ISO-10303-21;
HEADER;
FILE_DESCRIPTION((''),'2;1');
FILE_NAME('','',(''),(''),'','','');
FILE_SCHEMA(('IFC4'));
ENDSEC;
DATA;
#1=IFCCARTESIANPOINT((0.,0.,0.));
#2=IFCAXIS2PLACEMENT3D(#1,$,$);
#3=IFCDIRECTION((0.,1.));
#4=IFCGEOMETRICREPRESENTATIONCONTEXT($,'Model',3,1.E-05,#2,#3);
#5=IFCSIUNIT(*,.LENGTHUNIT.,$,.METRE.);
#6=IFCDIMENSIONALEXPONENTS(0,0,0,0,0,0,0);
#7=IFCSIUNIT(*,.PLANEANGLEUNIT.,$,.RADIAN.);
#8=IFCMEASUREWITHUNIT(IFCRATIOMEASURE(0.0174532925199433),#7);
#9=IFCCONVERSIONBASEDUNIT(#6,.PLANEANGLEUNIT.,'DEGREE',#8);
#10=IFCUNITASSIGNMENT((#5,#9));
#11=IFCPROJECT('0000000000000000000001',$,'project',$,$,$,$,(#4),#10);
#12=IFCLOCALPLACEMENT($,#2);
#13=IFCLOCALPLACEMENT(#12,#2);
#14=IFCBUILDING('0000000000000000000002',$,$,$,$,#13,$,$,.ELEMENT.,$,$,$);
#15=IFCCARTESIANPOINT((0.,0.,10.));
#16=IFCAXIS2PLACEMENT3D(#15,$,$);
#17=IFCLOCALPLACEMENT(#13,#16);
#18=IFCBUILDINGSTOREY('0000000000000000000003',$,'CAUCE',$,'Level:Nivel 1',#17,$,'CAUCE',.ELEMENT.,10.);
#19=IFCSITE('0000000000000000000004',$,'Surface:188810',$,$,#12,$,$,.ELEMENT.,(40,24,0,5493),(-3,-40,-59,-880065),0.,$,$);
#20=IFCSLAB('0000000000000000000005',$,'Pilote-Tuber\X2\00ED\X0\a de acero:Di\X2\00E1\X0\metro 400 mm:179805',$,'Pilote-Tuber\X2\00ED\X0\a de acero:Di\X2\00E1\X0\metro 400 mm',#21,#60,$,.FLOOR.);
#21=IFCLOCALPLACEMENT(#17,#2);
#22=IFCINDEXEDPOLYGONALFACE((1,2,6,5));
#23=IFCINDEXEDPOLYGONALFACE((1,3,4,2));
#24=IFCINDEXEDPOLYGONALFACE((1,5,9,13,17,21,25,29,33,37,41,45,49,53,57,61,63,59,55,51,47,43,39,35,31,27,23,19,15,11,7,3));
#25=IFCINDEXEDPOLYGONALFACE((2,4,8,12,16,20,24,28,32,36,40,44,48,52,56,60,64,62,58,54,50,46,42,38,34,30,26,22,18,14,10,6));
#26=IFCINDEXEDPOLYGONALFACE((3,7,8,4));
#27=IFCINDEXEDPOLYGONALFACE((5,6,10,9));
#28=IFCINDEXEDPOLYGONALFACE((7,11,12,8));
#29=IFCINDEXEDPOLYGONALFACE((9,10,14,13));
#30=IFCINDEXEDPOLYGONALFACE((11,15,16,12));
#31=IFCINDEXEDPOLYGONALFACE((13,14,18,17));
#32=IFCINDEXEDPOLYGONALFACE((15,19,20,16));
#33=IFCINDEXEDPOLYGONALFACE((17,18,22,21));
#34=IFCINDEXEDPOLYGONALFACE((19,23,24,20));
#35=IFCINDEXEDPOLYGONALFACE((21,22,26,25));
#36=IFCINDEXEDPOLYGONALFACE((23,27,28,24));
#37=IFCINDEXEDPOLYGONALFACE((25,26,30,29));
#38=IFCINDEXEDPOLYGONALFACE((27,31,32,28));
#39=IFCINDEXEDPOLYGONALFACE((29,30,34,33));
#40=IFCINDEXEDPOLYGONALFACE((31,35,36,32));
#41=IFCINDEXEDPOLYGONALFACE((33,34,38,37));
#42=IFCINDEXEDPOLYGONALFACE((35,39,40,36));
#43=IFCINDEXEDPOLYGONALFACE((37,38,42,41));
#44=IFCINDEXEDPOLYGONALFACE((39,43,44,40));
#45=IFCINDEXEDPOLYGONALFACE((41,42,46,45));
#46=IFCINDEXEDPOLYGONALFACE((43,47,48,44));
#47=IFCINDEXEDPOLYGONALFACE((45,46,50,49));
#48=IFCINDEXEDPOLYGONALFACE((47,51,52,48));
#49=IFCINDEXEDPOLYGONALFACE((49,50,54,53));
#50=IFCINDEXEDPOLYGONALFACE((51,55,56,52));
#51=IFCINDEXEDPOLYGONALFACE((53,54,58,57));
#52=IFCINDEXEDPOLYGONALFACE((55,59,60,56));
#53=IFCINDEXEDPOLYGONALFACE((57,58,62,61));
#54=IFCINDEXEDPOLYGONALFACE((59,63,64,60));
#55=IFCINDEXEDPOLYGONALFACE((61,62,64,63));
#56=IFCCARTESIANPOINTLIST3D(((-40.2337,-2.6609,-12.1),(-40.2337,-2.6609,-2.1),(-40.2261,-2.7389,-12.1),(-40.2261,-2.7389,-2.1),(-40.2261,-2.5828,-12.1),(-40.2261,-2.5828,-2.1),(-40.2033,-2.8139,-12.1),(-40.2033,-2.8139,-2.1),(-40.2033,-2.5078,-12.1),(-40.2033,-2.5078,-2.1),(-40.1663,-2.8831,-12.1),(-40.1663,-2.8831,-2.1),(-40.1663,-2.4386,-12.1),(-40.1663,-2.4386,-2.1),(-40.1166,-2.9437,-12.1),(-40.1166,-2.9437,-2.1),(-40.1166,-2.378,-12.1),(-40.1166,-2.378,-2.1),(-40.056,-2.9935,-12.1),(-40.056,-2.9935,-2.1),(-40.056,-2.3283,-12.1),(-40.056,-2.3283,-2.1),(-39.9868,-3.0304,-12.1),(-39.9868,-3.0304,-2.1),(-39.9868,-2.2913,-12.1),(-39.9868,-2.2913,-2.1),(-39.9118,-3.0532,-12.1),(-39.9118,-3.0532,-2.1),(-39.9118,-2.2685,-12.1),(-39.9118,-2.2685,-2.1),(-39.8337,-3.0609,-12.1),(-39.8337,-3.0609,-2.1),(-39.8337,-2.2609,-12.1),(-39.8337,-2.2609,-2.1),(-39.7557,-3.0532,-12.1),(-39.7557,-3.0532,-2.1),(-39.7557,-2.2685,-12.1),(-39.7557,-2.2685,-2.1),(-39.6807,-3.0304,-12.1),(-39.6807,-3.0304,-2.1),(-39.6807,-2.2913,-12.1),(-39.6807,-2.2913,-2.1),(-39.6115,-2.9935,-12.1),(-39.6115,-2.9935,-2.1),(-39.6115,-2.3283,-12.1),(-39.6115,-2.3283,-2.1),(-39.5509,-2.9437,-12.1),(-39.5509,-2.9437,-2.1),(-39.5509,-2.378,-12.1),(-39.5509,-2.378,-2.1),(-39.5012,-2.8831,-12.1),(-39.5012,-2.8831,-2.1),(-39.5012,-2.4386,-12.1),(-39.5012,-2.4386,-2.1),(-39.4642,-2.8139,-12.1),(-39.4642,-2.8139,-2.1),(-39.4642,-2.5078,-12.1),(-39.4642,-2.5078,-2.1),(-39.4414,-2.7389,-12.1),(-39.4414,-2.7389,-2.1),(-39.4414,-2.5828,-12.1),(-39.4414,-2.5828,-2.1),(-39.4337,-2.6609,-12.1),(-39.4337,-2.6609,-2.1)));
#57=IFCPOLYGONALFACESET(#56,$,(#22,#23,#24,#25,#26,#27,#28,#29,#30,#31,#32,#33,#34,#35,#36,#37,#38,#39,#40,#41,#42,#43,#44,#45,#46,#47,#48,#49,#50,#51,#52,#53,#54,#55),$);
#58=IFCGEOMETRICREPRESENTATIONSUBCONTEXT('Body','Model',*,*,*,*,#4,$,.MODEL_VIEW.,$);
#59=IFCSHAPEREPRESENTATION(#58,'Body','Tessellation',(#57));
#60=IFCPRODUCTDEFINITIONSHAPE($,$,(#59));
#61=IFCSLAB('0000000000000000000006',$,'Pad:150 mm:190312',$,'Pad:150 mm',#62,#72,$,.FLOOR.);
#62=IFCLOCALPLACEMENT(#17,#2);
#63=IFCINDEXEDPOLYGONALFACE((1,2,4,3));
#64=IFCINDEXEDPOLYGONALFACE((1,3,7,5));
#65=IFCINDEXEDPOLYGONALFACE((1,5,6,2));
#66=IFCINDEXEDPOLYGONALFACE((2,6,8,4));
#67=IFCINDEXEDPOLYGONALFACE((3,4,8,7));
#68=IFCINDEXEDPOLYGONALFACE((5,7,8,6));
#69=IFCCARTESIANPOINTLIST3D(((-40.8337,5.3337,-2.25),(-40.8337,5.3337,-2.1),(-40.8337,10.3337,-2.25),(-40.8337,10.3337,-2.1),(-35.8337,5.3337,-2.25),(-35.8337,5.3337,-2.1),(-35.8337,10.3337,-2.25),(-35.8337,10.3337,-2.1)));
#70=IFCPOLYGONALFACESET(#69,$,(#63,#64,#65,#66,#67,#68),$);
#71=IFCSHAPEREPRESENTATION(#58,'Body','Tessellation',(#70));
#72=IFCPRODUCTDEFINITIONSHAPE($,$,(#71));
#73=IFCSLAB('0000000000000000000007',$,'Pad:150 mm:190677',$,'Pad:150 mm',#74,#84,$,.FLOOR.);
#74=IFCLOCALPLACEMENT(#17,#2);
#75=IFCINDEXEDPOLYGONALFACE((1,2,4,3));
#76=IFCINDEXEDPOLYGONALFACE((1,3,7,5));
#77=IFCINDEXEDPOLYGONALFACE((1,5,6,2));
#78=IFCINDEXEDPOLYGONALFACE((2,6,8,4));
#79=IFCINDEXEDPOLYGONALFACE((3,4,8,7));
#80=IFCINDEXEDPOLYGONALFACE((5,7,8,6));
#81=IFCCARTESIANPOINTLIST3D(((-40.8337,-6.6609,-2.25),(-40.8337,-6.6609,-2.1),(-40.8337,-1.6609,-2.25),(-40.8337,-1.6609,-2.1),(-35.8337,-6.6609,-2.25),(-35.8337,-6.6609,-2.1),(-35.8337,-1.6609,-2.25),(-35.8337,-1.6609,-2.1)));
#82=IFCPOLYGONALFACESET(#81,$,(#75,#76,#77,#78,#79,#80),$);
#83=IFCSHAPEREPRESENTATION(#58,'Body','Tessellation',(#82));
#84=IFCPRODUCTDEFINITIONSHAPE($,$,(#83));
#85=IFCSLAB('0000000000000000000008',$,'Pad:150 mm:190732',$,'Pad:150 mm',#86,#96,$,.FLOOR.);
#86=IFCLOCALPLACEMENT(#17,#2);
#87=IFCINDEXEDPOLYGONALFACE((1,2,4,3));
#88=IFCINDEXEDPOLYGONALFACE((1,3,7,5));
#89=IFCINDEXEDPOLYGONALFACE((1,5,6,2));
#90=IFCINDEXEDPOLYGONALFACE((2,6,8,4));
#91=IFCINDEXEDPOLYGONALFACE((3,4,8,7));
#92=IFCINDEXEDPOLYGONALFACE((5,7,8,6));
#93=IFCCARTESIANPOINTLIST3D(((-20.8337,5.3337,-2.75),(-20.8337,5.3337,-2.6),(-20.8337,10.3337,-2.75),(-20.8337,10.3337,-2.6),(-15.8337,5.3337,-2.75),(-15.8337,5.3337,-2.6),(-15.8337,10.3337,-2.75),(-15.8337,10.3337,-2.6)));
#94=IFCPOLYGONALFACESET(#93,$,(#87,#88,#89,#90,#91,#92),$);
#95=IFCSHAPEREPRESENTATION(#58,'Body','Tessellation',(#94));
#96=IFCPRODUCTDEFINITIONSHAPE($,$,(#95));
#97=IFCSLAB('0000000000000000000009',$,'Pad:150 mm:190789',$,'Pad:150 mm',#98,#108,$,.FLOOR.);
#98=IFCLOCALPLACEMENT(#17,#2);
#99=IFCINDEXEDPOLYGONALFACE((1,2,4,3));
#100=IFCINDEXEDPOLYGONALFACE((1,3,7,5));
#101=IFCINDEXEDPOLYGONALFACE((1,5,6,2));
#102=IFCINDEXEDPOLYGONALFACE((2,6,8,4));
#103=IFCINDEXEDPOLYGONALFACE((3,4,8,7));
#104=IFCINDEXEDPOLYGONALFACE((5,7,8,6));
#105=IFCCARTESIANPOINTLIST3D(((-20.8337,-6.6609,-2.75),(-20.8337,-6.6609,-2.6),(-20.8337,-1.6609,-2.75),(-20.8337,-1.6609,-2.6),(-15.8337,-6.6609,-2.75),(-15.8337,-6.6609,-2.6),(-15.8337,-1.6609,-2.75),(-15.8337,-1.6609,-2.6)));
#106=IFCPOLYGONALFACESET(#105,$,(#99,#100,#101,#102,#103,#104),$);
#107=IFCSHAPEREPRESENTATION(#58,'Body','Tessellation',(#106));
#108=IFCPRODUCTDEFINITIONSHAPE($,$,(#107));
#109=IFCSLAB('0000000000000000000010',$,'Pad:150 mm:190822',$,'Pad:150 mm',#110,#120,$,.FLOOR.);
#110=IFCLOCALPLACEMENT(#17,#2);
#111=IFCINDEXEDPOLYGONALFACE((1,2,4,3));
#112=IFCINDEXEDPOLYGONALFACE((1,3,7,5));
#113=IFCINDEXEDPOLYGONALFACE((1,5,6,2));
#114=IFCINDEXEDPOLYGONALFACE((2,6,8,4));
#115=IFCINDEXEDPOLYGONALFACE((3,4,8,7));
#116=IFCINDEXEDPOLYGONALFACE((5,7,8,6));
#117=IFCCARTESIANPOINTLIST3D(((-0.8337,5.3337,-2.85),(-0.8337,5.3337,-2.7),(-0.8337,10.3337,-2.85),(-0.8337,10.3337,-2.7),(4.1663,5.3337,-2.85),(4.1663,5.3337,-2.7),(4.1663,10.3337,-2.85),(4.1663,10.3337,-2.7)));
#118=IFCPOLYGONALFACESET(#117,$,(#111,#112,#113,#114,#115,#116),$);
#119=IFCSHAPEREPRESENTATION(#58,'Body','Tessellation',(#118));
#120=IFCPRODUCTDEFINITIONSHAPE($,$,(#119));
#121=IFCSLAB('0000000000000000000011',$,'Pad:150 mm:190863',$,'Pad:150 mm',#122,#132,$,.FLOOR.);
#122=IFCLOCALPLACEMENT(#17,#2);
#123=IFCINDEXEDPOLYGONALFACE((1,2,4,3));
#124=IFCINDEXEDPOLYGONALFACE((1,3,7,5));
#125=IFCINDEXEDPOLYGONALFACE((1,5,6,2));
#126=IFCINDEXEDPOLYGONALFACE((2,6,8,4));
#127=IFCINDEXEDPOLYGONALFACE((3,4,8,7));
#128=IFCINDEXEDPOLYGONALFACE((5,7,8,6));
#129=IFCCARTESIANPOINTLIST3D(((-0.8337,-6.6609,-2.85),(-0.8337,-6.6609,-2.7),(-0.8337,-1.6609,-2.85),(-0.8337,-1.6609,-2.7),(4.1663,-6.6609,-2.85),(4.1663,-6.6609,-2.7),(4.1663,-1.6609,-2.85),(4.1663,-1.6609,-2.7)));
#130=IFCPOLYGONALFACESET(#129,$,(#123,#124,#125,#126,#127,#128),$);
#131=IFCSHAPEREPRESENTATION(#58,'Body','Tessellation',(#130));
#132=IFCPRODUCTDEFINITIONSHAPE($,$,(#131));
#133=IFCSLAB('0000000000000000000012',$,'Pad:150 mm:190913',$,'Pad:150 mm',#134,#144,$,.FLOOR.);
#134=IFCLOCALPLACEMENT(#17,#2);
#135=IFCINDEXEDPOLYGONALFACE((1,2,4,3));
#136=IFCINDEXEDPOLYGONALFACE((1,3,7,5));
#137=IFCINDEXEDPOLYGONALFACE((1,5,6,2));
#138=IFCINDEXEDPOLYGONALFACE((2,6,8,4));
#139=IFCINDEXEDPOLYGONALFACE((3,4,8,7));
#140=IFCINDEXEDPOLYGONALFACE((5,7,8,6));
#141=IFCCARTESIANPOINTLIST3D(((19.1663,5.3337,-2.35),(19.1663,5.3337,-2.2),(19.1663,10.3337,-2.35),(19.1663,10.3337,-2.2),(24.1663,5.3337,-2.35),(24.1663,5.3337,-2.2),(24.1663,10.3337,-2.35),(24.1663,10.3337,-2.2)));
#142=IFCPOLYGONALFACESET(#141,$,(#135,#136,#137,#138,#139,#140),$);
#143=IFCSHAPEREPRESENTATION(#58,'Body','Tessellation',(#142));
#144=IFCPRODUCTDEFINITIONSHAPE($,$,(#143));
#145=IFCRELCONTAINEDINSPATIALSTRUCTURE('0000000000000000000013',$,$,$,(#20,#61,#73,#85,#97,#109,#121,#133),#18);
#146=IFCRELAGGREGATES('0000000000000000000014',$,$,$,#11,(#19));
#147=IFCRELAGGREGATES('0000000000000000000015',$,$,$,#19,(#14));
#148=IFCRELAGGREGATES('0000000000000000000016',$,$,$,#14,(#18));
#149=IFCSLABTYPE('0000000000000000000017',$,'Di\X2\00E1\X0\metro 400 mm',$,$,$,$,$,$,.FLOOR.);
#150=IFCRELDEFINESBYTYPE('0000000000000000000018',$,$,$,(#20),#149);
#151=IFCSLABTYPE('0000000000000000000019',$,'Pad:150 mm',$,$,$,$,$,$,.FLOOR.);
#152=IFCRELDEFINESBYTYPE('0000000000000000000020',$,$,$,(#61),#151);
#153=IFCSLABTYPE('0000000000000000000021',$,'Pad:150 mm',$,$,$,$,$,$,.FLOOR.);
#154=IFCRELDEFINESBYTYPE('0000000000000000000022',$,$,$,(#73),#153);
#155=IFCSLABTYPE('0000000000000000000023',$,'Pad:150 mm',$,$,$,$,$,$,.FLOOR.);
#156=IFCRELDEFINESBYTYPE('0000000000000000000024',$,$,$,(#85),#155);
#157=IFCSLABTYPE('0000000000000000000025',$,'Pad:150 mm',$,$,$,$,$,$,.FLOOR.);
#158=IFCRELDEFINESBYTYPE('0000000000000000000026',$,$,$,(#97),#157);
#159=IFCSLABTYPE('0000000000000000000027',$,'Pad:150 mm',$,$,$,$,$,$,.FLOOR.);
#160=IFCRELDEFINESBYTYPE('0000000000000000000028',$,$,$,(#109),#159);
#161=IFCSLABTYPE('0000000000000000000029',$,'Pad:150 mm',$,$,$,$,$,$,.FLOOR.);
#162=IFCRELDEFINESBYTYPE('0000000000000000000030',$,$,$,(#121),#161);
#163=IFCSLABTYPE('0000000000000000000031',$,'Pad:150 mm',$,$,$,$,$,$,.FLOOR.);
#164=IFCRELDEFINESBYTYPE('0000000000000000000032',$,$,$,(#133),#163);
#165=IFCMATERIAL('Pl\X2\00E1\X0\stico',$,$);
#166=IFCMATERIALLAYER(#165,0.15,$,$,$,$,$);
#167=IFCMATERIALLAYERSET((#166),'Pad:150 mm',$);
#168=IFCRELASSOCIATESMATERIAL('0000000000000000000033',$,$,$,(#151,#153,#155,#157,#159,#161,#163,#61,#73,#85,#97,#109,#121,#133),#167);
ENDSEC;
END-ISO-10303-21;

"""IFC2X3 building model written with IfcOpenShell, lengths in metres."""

from ifc_helpers import new_model, entity, si_unit, converted_unit, direction, frame, frame_2d, origin, origin_2d_with_axis, place, context, subcontext, project, spatial, rectangle, circle, extrude, material, layer, layer_set, layer_usage, type_object, element, save


model = new_model("IFC2X3")

# Units and contexts
model_context = context("Model", 3, precision=1e-05, world=origin(), true_north=direction((0.0, 1.0)))
body_context = subcontext(model_context, "Body", "Model", "MODEL_VIEW")
ifc_project = project(units=[si_unit("LENGTHUNIT", "METRE"), converted_unit("PLANEANGLEUNIT", "DEGREE", entity("IfcRatioMeasure", 0.0174532925199433), si_unit("PLANEANGLEUNIT", "RADIAN"), dimensions=[0, 0, 0, 0, 0, 0, 0])], contexts=[model_context])

# Site, building, storey
site_placement = place(None, origin())
site = spatial("IfcSite", under=ifc_project, at=site_placement, Name="Surface:188810", CompositionType="ELEMENT", RefLatitude=(40, 24, 0, 5493), RefLongitude=(-3, -40, -59, -880065), RefElevation=0.0)
building_placement = place(site_placement, origin())
building = spatial("IfcBuilding", under=site, at=building_placement, CompositionType="ELEMENT")
storey_placement = place(building_placement, frame((0.0, 0.0, 10.0)))
storey = spatial("IfcBuildingStorey", under=building, at=storey_placement, Name="CAUCE", ObjectType="Level:Nivel 1", LongName="CAUCE", CompositionType="ELEMENT", Elevation=10.0)

# Slabs
slab_type_1 = type_object("IfcSlabType", Name="Diámetro 400 mm", PredefinedType="FLOOR")
slab_1_placement = place(storey_placement, origin())
element("IfcSlab", 1, at=slab_1_placement, inside=storey, type_object=slab_type_1, Name="Pilote-Tubería de acero:Diámetro 400 mm:179805", ObjectType="Pilote-Tubería de acero:Diámetro 400 mm", PredefinedType="FLOOR", context=body_context, shape_type="SweptSolid", body=[
    extrude(circle(Radius=0.4, at=frame_2d((0.0, 0.0), x_axis=(1.0, 0.0))), frame((-39.8337, -2.6609, -12.1)), (0.0, 0.0, 1.0), 10.0),
])
ifc_material_1 = material(Name="Plástico")
ifc_layer = layer(ifc_material_1, 0.15)
ifc_layer_set = layer_set([ifc_layer], Name="Pad:150 mm")
ifc_layer_usage_1 = layer_usage(ifc_layer_set, "AXIS3", "POSITIVE", 0.0)
slab_type_2 = type_object("IfcSlabType", Name="Pad:150 mm", PredefinedType="FLOOR", material=ifc_layer_set)
slab_2_placement = place(storey_placement, origin())
element("IfcSlab", 2, at=slab_2_placement, inside=storey, type_object=slab_type_2, material=ifc_layer_usage_1, Name="Pad:150 mm:190312", ObjectType="Pad:150 mm", PredefinedType="FLOOR", context=body_context, shape_type="SweptSolid", body=[
    extrude(rectangle(XDim=5.0, YDim=5.0, at=origin_2d_with_axis()), frame((-38.3337, 7.8337, -2.25), z_axis=(0.0, 0.0, 1.0), x_axis=(0.0, 1.0, 0.0)), (0.0, 0.0, 1.0), 0.15),
])
ifc_layer_usage_2 = layer_usage(ifc_layer_set, "AXIS3", "POSITIVE", 0.0)
slab_type_3 = type_object("IfcSlabType", Name="Pad:150 mm", PredefinedType="FLOOR", material=ifc_layer_set)
slab_3_placement = place(storey_placement, origin())
element("IfcSlab", 3, at=slab_3_placement, inside=storey, type_object=slab_type_3, material=ifc_layer_usage_2, Name="Pad:150 mm:190677", ObjectType="Pad:150 mm", PredefinedType="FLOOR", context=body_context, shape_type="SweptSolid", body=[
    extrude(rectangle(XDim=5.0, YDim=5.0, at=frame_2d((0.0, 0.0), x_axis=(1.0, 0.0))), frame((-38.3337, -4.1609, -2.25), z_axis=(0.0, 0.0, 1.0), x_axis=(-1.0, 0.0, 0.0)), (0.0, 0.0, 1.0), 0.15),
])
ifc_layer_usage_3 = layer_usage(ifc_layer_set, "AXIS3", "POSITIVE", 0.0)
slab_type_4 = type_object("IfcSlabType", Name="Pad:150 mm", PredefinedType="FLOOR", material=ifc_layer_set)
slab_4_placement = place(storey_placement, origin())
element("IfcSlab", 4, at=slab_4_placement, inside=storey, type_object=slab_type_4, material=ifc_layer_usage_3, Name="Pad:150 mm:190732", ObjectType="Pad:150 mm", PredefinedType="FLOOR", context=body_context, shape_type="SweptSolid", body=[
    extrude(rectangle(XDim=5.0, YDim=5.0, at=origin_2d_with_axis()), frame((-18.3337, 7.8337, -2.75), z_axis=(0.0, 0.0, 1.0), x_axis=(-1.0, 0.0, 0.0)), (0.0, 0.0, 1.0), 0.15),
])
ifc_layer_usage_4 = layer_usage(ifc_layer_set, "AXIS3", "POSITIVE", 0.0)
slab_type_5 = type_object("IfcSlabType", Name="Pad:150 mm", PredefinedType="FLOOR", material=ifc_layer_set)
slab_5_placement = place(storey_placement, origin())
element("IfcSlab", 5, at=slab_5_placement, inside=storey, type_object=slab_type_5, material=ifc_layer_usage_4, Name="Pad:150 mm:190789", ObjectType="Pad:150 mm", PredefinedType="FLOOR", context=body_context, shape_type="SweptSolid", body=[
    extrude(rectangle(XDim=5.0, YDim=5.0, at=frame_2d((0.0, 0.0), x_axis=(1.0, 0.0))), frame((-18.3337, -4.1609, -2.75), z_axis=(0.0, 0.0, 1.0), x_axis=(-1.0, 0.0, 0.0)), (0.0, 0.0, 1.0), 0.15),
])
ifc_layer_usage_5 = layer_usage(ifc_layer_set, "AXIS3", "POSITIVE", 0.0)
slab_type_6 = type_object("IfcSlabType", Name="Pad:150 mm", PredefinedType="FLOOR", material=ifc_layer_set)
slab_6_placement = place(storey_placement, origin())
element("IfcSlab", 6, at=slab_6_placement, inside=storey, type_object=slab_type_6, material=ifc_layer_usage_5, Name="Pad:150 mm:190822", ObjectType="Pad:150 mm", PredefinedType="FLOOR", context=body_context, shape_type="SweptSolid", body=[
    extrude(rectangle(XDim=5.0, YDim=5.0, at=origin_2d_with_axis()), frame((1.6663, 7.8337, -2.85), z_axis=(0.0, 0.0, 1.0), x_axis=(-1.0, 0.0, 0.0)), (0.0, 0.0, 1.0), 0.15),
])
ifc_layer_usage_6 = layer_usage(ifc_layer_set, "AXIS3", "POSITIVE", 0.0)
slab_type_7 = type_object("IfcSlabType", Name="Pad:150 mm", PredefinedType="FLOOR", material=ifc_layer_set)
slab_7_placement = place(storey_placement, origin())
element("IfcSlab", 7, at=slab_7_placement, inside=storey, type_object=slab_type_7, material=ifc_layer_usage_6, Name="Pad:150 mm:190863", ObjectType="Pad:150 mm", PredefinedType="FLOOR", context=body_context, shape_type="SweptSolid", body=[
    extrude(rectangle(XDim=5.0, YDim=5.0, at=frame_2d((0.0, 0.0), x_axis=(1.0, 0.0))), frame((1.6663, -4.1609, -2.85), z_axis=(0.0, 0.0, 1.0), x_axis=(-1.0, 0.0, 0.0)), (0.0, 0.0, 1.0), 0.15),
])
ifc_layer_usage_7 = layer_usage(ifc_layer_set, "AXIS3", "POSITIVE", 0.0)
slab_type_8 = type_object("IfcSlabType", Name="Pad:150 mm", PredefinedType="FLOOR", material=ifc_layer_set)
slab_8_placement = place(storey_placement, origin())
element("IfcSlab", 8, at=slab_8_placement, inside=storey, type_object=slab_type_8, material=ifc_layer_usage_7, Name="Pad:150 mm:190913", ObjectType="Pad:150 mm", PredefinedType="FLOOR", context=body_context, shape_type="SweptSolid", body=[
    extrude(rectangle(XDim=5.0, YDim=5.0, at=origin_2d_with_axis()), frame((21.6663, 7.8337, -2.35), z_axis=(0.0, 0.0, 1.0), x_axis=(-1.0, 0.0, 0.0)), (0.0, 0.0, 1.0), 0.15),
])

save(model, "model.ifc")
